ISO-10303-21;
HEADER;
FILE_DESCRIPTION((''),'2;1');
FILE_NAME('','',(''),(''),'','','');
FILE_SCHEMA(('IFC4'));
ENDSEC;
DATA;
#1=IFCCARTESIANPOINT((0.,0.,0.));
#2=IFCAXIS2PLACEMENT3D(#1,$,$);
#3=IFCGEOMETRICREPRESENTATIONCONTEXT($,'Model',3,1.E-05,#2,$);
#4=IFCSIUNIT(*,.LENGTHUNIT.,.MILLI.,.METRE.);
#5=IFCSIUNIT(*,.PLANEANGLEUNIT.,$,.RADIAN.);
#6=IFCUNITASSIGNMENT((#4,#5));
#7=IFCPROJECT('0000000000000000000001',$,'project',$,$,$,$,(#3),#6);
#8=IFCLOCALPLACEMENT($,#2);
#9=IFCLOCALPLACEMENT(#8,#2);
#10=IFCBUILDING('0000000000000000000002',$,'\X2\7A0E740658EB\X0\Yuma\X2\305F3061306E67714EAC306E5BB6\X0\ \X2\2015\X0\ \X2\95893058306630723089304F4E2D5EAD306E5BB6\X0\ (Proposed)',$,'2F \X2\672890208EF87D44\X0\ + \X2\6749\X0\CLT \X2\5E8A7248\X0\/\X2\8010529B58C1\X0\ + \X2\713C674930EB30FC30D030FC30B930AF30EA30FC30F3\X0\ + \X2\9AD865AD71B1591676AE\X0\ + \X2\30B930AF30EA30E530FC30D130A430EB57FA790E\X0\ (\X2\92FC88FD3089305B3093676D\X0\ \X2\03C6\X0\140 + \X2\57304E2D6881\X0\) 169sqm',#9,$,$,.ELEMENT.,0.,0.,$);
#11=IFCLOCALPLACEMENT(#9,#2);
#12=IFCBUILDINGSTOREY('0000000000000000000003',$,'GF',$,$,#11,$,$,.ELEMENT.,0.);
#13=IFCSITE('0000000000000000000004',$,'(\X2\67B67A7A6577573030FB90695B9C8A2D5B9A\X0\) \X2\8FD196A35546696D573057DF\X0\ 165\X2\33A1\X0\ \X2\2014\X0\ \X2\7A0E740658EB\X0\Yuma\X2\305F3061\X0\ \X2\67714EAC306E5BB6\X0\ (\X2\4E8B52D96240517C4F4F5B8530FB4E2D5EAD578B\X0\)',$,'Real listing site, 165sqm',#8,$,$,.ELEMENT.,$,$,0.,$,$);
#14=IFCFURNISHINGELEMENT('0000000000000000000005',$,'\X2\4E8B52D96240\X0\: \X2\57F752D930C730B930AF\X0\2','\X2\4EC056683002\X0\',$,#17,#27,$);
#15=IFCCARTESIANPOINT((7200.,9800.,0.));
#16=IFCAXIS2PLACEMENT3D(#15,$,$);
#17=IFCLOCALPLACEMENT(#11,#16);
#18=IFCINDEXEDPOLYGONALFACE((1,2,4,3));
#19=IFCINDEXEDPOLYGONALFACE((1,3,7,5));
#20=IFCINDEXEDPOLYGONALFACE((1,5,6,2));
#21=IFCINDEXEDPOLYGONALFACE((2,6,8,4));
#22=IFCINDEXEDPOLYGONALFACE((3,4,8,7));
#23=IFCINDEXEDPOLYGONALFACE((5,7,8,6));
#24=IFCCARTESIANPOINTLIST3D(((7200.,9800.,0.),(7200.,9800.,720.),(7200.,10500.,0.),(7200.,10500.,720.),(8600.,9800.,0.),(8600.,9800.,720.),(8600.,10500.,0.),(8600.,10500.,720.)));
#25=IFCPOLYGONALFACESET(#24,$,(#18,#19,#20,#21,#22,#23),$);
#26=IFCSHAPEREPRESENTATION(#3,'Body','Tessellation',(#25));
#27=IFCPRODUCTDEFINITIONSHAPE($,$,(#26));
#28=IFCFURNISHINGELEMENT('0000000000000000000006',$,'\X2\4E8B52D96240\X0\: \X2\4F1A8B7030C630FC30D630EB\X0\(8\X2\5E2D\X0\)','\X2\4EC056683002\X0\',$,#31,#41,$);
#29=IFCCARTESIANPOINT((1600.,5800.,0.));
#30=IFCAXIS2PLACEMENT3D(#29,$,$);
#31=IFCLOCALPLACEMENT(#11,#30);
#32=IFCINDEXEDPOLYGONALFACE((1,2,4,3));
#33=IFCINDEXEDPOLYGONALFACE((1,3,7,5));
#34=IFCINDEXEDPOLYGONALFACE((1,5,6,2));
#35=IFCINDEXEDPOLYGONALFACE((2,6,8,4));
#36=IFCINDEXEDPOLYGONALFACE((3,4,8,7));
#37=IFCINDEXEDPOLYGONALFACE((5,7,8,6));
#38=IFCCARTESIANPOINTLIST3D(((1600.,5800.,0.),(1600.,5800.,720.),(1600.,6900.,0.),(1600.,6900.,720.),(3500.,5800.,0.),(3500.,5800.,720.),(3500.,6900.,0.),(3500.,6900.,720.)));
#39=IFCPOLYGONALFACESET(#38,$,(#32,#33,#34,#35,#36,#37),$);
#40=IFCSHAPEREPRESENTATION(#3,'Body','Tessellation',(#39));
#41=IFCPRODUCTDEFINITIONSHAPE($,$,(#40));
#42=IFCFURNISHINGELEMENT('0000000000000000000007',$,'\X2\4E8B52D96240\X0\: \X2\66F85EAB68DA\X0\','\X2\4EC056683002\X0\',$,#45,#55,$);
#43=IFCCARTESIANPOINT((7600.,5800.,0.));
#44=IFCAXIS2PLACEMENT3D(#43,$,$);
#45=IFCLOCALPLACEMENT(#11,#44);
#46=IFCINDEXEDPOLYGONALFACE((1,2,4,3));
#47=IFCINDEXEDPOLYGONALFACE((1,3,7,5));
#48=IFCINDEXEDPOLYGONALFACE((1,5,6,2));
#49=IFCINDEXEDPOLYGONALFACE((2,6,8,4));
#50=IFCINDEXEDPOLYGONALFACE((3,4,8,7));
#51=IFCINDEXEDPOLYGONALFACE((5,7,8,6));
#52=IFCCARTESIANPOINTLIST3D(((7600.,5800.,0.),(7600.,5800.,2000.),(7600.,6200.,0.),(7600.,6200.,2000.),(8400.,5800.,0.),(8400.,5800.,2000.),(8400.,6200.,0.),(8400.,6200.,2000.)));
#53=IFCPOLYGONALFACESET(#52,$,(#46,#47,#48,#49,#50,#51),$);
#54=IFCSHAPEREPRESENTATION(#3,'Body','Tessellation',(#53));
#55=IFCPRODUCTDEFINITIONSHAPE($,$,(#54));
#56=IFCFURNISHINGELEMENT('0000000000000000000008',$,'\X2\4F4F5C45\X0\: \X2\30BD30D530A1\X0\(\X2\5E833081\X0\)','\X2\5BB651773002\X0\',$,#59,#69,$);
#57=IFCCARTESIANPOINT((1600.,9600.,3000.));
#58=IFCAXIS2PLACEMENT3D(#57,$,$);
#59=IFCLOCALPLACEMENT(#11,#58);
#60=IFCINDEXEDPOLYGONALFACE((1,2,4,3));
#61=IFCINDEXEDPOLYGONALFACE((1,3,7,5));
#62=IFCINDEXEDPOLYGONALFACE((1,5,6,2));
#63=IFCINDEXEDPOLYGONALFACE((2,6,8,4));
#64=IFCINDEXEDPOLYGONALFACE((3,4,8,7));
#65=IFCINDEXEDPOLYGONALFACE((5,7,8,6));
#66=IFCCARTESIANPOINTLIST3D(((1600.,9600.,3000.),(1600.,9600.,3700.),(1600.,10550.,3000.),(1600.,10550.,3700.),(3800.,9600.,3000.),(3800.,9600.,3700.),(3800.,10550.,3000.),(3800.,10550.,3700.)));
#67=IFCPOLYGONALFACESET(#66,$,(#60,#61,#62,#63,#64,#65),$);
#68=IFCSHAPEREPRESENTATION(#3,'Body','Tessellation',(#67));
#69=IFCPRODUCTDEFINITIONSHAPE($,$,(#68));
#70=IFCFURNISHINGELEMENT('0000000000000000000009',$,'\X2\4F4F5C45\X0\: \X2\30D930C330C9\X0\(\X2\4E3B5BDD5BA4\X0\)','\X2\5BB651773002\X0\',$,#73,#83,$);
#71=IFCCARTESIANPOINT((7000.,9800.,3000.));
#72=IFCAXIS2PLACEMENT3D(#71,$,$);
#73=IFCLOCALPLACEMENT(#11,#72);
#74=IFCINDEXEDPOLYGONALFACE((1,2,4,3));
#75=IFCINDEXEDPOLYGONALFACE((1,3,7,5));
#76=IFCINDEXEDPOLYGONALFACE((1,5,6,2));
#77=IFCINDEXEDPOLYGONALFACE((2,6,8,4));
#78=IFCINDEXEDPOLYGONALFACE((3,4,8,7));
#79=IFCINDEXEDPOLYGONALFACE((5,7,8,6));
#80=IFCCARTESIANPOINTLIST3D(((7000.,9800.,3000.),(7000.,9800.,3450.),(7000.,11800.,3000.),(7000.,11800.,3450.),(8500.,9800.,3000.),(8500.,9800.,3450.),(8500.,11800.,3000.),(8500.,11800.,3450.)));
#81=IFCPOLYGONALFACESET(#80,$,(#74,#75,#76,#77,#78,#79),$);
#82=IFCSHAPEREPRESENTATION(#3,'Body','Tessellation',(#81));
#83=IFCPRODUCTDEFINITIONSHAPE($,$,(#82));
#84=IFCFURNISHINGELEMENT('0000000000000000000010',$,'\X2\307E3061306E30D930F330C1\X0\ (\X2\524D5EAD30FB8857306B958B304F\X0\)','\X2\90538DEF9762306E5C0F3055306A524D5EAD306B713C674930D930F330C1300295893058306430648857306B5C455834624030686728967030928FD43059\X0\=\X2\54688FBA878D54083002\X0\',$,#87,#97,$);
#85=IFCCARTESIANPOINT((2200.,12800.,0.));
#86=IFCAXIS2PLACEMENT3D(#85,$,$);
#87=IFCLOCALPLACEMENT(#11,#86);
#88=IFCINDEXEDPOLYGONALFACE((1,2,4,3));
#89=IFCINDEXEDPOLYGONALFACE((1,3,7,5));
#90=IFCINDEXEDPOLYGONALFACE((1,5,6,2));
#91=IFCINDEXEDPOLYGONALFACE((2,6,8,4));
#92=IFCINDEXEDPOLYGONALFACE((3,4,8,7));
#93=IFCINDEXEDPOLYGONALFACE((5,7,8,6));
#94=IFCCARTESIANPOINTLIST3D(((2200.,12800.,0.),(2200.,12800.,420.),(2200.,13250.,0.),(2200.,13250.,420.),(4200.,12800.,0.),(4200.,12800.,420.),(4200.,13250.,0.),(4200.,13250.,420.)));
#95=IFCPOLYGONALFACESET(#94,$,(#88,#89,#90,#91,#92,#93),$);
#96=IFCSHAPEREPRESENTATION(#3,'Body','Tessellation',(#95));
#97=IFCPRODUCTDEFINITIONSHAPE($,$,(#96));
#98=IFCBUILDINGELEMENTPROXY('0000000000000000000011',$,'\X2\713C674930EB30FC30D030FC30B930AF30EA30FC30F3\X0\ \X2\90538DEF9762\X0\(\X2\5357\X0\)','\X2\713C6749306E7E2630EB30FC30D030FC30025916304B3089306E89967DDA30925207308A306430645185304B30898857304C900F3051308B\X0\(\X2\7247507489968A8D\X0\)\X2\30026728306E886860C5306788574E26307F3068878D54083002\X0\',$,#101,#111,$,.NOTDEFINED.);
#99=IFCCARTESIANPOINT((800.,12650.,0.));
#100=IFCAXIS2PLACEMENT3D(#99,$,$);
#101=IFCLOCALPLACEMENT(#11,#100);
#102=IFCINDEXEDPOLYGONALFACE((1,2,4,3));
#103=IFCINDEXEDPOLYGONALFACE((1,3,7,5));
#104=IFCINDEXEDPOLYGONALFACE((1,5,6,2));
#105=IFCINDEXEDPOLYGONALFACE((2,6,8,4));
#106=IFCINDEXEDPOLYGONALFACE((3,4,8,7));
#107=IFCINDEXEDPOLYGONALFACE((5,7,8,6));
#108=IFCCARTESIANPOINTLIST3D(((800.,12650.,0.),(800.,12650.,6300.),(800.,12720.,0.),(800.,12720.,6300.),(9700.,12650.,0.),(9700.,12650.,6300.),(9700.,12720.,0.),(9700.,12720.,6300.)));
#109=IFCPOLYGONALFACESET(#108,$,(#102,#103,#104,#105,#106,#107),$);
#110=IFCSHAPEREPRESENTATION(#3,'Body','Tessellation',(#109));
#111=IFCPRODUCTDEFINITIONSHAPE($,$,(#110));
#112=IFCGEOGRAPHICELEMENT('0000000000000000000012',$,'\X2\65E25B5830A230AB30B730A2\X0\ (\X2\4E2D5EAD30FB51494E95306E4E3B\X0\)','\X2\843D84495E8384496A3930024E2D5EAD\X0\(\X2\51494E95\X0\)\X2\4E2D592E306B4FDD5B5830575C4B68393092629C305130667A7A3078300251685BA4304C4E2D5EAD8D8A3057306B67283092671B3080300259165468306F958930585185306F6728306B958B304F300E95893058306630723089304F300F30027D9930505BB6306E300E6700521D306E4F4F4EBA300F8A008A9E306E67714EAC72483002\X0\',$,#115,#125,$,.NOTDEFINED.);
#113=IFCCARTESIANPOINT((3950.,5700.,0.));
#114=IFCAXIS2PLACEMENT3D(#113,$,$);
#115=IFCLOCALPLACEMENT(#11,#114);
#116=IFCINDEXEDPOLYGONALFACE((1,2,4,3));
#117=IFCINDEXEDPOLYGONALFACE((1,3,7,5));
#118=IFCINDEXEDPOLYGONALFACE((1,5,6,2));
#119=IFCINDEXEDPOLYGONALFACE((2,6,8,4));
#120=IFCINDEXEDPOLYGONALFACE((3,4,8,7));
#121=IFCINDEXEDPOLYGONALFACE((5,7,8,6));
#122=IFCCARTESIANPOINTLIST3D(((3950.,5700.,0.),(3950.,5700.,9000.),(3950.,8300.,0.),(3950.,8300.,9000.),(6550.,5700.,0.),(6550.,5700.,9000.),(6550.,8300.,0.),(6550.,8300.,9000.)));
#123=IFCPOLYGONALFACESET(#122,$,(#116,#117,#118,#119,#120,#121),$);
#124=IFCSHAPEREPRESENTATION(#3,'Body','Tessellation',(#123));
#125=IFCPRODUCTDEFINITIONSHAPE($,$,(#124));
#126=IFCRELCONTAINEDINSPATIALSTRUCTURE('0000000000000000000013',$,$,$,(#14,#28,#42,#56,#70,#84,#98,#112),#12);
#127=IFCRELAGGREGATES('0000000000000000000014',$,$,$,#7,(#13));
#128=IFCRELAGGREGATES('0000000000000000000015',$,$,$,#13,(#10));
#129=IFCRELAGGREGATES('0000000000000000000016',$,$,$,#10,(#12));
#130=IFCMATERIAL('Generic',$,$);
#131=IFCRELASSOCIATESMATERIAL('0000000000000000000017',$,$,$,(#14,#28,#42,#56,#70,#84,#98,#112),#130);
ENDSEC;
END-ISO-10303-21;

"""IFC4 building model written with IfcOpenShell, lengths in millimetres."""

from ifc_helpers import new_model, si_unit, frame, frame_2d, origin, place, context, project, spatial, rectangle, extrude, material, element, save


model = new_model("IFC4")

# Units and contexts
model_context = context("Model", 3, precision=1e-05, world=origin())
ifc_project = project(units=[si_unit("LENGTHUNIT", "METRE", prefix="MILLI"), si_unit("PLANEANGLEUNIT", "RADIAN")], contexts=[model_context])

# Site, building, storey
site_placement = place(None, origin())
site = spatial("IfcSite", under=ifc_project, at=site_placement, Name="(架空敷地・適宜設定) 近隣商業地域 165㎡ — 税理士Yumaたち 東京の家 (事務所兼住宅・中庭型)", ObjectType="Real listing site, 165sqm", CompositionType="ELEMENT", RefElevation=0.0)
building_placement = place(site_placement, origin())
building = spatial("IfcBuilding", under=site, at=building_placement, Name="税理士Yumaたちの東京の家 ― 閉じてひらく中庭の家 (Proposed)", ObjectType="2F 木造軸組 + 杉CLT 床版/耐力壁 + 焼杉ルーバースクリーン + 高断熱外皮 + スクリューパイル基礎 (鋼製らせん杭 φ140 + 地中梁) 169sqm", CompositionType="ELEMENT", ElevationOfRefHeight=0.0, ElevationOfTerrain=0.0)
storey_placement = place(building_placement, origin())
storey = spatial("IfcBuildingStorey", under=building, at=storey_placement, Name="GF", CompositionType="ELEMENT", Elevation=0.0)

# Shared definitions
ifc_material_1 = material(Name="Generic")

# Furnishing elements
furnishing_1_placement = place(storey_placement, frame((7200.0, 9800.0, 0.0)))
element("IfcFurnishingElement", 1, at=furnishing_1_placement, inside=storey, material=ifc_material_1, Name="事務所: 執務デスク2", Description="什器。", context=model_context, shape_type="SweptSolid", body=[
    extrude(rectangle(XDim=1400.0, YDim=700.0, at=frame_2d((700.0, 350.0))), frame((7200.0, 9800.0, 0.0)), (0.0, 0.0, 1.0), 720.0),
])
furnishing_2_placement = place(storey_placement, frame((1600.0, 5800.0, 0.0)))
element("IfcFurnishingElement", 2, at=furnishing_2_placement, inside=storey, material=ifc_material_1, Name="事務所: 会議テーブル(8席)", Description="什器。", context=model_context, shape_type="SweptSolid", body=[
    extrude(rectangle(XDim=1900.0, YDim=1100.0, at=frame_2d((950.0, 550.0))), frame((1600.0, 5800.0, 0.0)), (0.0, 0.0, 1.0), 720.0),
])
furnishing_3_placement = place(storey_placement, frame((7600.0, 5800.0, 0.0)))
element("IfcFurnishingElement", 3, at=furnishing_3_placement, inside=storey, material=ifc_material_1, Name="事務所: 書庫棚", Description="什器。", context=model_context, shape_type="SweptSolid", body=[
    extrude(rectangle(XDim=800.0, YDim=400.0, at=frame_2d((400.0, 200.0))), frame((7600.0, 5800.0, 0.0)), (0.0, 0.0, 1.0), 2000.0),
])
furnishing_4_placement = place(storey_placement, frame((1600.0, 9600.0, 3000.0)))
element("IfcFurnishingElement", 4, at=furnishing_4_placement, inside=storey, material=ifc_material_1, Name="住居: ソファ(広め)", Description="家具。", context=model_context, shape_type="SweptSolid", body=[
    extrude(rectangle(XDim=2200.0, YDim=950.0, at=frame_2d((1100.0, 475.0))), frame((1600.0, 9600.0, 3000.0)), (0.0, 0.0, 1.0), 700.0),
])
furnishing_5_placement = place(storey_placement, frame((7000.0, 9800.0, 3000.0)))
element("IfcFurnishingElement", 5, at=furnishing_5_placement, inside=storey, material=ifc_material_1, Name="住居: ベッド(主寝室)", Description="家具。", context=model_context, shape_type="SweptSolid", body=[
    extrude(rectangle(XDim=1500.0, YDim=2000.0, at=frame_2d((750.0, 1000.0))), frame((7000.0, 9800.0, 3000.0)), (0.0, 0.0, 1.0), 450.0),
])
furnishing_6_placement = place(storey_placement, frame((2200.0, 12800.0, 0.0)))
element("IfcFurnishingElement", 6, at=furnishing_6_placement, inside=storey, material=ifc_material_1, Name="まちのベンチ (前庭・街に開く)", Description="道路面の小さな前庭に焼杉ベンチ。閉じつつ街に居場所と木陰を返す=周辺融合。", context=model_context, shape_type="SweptSolid", body=[
    extrude(rectangle(XDim=2000.0, YDim=450.0, at=frame_2d((1000.0, 225.0))), frame((2200.0, 12800.0, 0.0)), (0.0, 0.0, 1.0), 420.0),
])

# Building element proxy
proxy_placement = place(storey_placement, frame((800.0, 12650.0, 0.0)))
element("IfcBuildingElementProxy", 7, at=proxy_placement, inside=storey, material=ifc_material_1, Name="焼杉ルーバースクリーン 道路面(南)", Description="焼杉の縦ルーバー。外からの視線を切りつつ内から街が透ける(片側視認)。木の表情で街並みと融合。", PredefinedType="NOTDEFINED", context=model_context, shape_type="SweptSolid", body=[
    extrude(rectangle(XDim=8900.0, YDim=70.0, at=frame_2d((4450.0, 35.0))), frame((800.0, 12650.0, 0.0)), (0.0, 0.0, 1.0), 6300.0),
])

# Geographic element
geographic_element_placement = place(storey_placement, frame((3950.0, 5700.0, 0.0)))
element("IfcGeographicElement", 8, at=geographic_element_placement, inside=storey, material=ifc_material_1, Name="既存アカシア (中庭・光井の主)", Description="落葉広葉樹。中庭(光井)中央に保存し屋根を抜けて空へ。全室が中庭越しに木を望む。外周は閉じ内は木に開く『閉じてひらく』。継ぐ家の『最初の住人』言語の東京版。", PredefinedType="NOTDEFINED", context=model_context, shape_type="SweptSolid", body=[
    extrude(rectangle(XDim=2600.0, YDim=2600.0, at=frame_2d((1300.0, 1300.0))), frame((3950.0, 5700.0, 0.0)), (0.0, 0.0, 1.0), 9000.0),
])

save(model, "model.ifc")
